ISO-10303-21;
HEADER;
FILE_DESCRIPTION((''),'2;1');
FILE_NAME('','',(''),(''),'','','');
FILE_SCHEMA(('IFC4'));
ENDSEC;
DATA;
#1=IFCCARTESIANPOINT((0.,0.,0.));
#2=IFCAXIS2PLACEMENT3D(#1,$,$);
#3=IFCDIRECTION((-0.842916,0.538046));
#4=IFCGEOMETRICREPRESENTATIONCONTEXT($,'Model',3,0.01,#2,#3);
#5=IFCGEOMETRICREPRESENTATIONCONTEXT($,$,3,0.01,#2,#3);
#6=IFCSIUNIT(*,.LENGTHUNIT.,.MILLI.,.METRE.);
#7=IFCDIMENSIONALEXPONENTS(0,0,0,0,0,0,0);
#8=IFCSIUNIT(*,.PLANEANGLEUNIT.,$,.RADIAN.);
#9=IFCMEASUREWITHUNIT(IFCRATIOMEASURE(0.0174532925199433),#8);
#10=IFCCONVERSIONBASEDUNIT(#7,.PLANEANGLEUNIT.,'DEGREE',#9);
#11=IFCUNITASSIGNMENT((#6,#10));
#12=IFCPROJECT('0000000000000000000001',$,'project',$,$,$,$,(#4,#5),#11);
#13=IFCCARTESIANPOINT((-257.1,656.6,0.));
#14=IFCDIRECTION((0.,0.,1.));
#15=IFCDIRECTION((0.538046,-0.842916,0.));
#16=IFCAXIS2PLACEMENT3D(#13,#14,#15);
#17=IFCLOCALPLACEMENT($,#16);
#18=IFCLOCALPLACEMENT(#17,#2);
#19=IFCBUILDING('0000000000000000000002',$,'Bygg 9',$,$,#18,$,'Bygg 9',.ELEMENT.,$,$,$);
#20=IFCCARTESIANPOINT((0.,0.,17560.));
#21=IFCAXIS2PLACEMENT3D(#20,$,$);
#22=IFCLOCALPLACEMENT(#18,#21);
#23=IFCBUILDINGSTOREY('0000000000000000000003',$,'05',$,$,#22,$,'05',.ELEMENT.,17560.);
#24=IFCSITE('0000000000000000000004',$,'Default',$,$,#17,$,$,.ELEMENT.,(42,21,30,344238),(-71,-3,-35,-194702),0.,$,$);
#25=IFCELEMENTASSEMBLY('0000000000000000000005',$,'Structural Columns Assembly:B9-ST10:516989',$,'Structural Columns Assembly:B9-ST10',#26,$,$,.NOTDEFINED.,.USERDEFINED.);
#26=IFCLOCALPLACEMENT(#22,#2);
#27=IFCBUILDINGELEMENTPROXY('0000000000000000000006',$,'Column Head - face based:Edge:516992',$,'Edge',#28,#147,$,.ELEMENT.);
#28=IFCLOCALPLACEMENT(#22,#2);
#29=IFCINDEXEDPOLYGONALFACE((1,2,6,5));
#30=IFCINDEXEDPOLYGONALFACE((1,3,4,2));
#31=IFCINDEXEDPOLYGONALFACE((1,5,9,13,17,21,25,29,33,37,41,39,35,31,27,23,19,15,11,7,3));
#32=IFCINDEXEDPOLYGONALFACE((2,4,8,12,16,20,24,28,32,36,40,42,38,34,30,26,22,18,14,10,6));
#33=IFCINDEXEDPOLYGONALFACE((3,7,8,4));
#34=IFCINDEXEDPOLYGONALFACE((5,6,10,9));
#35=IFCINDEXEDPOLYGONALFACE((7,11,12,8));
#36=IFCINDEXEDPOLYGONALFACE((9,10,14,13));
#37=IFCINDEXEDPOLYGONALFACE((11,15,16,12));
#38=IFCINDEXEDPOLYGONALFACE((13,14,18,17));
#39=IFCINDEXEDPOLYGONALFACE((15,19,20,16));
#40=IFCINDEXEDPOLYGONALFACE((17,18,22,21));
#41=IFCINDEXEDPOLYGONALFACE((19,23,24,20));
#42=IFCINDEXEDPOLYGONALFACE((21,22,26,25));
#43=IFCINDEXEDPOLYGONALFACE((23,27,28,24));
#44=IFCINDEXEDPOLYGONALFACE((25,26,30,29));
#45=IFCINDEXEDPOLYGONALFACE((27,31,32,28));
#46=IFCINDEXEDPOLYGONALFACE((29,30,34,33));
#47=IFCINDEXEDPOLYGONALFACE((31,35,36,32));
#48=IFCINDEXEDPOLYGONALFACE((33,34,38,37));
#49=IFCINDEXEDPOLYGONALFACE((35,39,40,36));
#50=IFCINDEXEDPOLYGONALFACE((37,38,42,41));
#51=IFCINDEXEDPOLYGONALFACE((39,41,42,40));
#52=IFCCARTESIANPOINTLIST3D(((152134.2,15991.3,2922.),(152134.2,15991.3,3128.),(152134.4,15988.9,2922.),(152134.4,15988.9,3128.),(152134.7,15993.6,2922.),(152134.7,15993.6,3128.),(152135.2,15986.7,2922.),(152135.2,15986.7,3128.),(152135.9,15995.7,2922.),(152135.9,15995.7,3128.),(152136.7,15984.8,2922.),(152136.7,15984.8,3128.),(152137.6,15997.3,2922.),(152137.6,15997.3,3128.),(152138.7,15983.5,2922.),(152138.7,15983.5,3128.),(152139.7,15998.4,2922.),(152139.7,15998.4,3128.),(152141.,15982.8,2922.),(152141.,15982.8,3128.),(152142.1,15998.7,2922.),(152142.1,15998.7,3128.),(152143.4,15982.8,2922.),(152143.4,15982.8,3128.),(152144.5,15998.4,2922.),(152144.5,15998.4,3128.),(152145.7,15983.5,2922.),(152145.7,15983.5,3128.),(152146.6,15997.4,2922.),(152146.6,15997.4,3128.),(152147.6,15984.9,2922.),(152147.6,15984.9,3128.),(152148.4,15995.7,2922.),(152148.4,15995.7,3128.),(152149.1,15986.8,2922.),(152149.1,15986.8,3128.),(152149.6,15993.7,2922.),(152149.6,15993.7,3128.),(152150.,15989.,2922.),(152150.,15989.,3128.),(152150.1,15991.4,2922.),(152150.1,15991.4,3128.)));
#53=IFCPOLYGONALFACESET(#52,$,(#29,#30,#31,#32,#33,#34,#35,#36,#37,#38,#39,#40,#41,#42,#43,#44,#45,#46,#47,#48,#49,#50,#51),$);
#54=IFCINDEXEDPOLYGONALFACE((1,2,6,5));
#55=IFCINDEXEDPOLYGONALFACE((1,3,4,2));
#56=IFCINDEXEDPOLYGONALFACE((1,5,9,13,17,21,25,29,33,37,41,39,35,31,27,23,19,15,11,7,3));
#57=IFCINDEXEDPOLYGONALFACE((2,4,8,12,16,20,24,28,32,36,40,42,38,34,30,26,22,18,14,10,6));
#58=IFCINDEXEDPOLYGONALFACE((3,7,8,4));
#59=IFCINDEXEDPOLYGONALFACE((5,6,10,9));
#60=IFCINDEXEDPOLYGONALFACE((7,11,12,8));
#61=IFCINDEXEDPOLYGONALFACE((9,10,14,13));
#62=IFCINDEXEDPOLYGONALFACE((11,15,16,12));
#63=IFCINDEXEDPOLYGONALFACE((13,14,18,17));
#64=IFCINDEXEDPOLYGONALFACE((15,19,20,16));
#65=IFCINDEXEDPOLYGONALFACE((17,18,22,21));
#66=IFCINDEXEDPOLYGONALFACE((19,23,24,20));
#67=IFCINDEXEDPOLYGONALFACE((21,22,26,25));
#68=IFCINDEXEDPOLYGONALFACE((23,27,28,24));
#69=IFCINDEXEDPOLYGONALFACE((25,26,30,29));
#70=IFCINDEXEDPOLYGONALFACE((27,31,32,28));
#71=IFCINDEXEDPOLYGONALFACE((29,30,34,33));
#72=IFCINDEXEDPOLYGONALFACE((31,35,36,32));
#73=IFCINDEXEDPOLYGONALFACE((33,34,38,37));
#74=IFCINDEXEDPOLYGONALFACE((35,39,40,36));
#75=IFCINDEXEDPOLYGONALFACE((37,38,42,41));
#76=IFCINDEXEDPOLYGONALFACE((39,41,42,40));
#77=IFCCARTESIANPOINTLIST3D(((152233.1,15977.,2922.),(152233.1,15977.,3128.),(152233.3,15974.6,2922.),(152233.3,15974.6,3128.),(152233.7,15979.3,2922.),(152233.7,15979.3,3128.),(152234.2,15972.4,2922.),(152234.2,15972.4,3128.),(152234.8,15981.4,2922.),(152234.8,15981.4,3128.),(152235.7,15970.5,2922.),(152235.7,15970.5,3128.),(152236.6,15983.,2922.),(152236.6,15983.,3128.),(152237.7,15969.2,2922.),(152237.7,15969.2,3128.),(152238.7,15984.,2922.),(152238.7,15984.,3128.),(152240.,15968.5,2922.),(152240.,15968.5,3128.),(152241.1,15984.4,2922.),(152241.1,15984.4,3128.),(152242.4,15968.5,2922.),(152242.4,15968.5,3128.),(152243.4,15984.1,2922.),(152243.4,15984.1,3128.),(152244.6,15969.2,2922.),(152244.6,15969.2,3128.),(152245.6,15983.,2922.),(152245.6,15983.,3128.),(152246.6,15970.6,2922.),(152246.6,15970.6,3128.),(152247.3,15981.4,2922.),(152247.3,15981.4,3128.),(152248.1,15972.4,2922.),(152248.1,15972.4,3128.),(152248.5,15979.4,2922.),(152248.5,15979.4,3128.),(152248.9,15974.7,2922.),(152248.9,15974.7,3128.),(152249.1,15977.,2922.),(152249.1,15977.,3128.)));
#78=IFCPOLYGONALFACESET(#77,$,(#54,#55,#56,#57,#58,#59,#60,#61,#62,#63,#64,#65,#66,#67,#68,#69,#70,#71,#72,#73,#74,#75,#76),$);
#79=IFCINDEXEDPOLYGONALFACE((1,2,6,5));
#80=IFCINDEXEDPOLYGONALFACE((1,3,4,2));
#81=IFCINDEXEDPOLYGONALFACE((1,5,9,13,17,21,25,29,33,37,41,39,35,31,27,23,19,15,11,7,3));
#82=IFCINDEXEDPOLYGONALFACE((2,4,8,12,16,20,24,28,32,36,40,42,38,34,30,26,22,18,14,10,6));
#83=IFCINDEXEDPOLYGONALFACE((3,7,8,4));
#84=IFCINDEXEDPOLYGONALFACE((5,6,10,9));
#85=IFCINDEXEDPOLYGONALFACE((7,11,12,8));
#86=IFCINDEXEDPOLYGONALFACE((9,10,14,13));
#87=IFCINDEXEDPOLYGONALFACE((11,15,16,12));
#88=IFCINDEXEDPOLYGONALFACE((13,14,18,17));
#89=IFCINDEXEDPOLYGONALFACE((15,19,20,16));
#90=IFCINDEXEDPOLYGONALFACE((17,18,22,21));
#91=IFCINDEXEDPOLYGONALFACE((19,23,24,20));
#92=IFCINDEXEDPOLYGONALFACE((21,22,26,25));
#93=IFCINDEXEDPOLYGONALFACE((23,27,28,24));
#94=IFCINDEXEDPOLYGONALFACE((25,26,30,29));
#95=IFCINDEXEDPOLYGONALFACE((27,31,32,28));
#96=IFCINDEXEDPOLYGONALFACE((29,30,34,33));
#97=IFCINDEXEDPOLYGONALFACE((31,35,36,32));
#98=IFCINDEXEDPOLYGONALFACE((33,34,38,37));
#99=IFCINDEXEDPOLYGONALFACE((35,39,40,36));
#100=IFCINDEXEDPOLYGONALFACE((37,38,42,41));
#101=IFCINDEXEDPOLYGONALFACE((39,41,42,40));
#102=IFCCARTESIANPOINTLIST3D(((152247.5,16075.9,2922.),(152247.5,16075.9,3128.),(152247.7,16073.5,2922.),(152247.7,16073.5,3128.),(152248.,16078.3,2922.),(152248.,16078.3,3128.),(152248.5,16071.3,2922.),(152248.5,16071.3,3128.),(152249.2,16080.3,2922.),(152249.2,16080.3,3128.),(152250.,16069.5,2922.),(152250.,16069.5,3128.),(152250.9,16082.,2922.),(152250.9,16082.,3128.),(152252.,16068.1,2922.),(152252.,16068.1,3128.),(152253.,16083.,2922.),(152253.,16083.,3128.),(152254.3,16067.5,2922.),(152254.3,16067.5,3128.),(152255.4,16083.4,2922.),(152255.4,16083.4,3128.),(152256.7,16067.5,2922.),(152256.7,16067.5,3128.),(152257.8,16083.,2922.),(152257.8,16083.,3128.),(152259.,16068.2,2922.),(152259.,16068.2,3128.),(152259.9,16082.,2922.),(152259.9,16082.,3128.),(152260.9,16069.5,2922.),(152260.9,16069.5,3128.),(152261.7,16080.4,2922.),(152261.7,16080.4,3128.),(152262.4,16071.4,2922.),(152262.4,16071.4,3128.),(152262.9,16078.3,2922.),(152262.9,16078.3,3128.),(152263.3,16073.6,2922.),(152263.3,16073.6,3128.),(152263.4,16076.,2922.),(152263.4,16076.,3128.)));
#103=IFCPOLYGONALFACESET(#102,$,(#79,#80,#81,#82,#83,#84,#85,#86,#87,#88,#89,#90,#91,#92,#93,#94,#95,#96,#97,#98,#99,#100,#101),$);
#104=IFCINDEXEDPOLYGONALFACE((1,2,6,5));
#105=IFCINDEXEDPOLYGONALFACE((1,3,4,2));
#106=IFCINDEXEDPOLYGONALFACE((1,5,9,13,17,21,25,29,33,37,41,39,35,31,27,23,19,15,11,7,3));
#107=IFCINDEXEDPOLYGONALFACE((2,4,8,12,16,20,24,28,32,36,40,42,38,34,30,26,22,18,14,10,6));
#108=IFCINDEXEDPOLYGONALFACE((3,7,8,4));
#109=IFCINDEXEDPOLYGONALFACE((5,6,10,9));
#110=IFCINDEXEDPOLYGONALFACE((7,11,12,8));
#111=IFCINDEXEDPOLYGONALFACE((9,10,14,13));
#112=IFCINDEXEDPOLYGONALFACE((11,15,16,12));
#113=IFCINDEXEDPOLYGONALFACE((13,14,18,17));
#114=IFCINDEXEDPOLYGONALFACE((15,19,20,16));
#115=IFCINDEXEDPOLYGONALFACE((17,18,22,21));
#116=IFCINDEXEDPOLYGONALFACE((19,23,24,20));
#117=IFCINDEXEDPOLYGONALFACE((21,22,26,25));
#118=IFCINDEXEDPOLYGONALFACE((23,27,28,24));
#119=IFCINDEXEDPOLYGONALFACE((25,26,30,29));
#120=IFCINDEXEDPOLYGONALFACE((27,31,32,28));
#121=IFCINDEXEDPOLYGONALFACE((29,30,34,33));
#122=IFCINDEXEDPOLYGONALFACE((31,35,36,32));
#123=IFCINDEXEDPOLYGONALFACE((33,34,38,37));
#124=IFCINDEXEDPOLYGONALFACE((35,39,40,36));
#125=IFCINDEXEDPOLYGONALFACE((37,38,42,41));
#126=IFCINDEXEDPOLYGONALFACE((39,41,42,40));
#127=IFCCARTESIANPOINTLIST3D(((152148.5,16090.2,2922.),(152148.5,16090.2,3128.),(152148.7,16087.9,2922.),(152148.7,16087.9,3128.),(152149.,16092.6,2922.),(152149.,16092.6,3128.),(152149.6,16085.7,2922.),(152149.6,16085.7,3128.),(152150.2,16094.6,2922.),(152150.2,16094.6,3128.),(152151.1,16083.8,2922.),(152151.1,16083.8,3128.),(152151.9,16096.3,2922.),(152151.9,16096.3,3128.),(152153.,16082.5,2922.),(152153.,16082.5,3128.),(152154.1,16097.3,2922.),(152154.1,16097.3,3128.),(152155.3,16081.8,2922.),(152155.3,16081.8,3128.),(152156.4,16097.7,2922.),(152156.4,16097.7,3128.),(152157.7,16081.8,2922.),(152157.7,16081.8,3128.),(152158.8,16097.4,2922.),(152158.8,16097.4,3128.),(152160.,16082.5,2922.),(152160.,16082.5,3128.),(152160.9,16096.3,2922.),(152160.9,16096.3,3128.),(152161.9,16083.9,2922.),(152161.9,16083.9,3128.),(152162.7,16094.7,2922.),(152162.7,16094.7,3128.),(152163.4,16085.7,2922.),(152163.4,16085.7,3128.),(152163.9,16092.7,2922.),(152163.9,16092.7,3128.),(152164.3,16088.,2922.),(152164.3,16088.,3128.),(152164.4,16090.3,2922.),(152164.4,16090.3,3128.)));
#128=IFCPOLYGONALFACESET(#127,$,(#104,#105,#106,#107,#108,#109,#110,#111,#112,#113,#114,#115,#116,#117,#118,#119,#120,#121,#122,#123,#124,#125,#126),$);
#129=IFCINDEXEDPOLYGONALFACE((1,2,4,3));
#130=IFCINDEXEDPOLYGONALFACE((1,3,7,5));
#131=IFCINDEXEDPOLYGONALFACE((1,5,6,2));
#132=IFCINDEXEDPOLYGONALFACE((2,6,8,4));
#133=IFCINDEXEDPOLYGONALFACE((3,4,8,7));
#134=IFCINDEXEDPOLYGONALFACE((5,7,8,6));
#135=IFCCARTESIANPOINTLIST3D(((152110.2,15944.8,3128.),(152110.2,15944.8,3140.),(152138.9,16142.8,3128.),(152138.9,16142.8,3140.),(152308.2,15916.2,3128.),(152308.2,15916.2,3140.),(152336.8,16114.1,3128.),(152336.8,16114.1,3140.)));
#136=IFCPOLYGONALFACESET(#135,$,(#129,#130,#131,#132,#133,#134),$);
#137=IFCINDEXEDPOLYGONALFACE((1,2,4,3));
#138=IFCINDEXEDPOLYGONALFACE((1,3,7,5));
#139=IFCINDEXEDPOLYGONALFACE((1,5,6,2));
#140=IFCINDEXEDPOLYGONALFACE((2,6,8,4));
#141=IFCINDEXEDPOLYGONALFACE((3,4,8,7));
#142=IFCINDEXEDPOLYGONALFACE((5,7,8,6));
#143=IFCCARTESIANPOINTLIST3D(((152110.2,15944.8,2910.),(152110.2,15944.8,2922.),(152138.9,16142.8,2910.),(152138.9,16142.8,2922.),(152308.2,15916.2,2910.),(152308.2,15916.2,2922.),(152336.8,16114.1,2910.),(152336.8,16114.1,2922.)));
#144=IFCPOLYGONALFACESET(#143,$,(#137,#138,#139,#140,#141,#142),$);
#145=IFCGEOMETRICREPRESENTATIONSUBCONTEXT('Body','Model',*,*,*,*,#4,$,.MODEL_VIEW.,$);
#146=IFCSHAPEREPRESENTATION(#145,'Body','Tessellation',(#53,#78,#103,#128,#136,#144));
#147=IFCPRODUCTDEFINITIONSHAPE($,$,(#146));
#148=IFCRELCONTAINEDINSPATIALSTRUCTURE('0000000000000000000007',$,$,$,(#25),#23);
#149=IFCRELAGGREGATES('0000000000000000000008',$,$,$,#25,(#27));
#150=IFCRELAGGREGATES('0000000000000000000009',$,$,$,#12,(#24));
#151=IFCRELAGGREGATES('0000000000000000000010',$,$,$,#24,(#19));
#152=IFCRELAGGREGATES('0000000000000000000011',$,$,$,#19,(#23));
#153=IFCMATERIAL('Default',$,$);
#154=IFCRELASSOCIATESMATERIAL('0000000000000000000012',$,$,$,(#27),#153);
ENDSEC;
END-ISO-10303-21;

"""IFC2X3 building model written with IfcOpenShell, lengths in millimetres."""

from ifc_helpers import new_model, entity, si_unit, converted_unit, direction, frame, frame_2d, origin, origin_2d_with_axis, place, context, subcontext, project, spatial, rectangle, circle, extrude, source, transform, mapped, material, element, aggregate, save


model = new_model("IFC2X3")

# Units and contexts
model_context = context("Model", 3, precision=0.01, world=origin(), true_north=direction((-0.842916, 0.538046)))
context_of_model = context(None, 3, precision=0.01, world=origin(), true_north=direction((-0.842916, 0.538046)))
body_context = subcontext(model_context, "Body", "Model", "MODEL_VIEW")
ifc_project = project(units=[si_unit("LENGTHUNIT", "METRE", prefix="MILLI"), converted_unit("PLANEANGLEUNIT", "DEGREE", entity("IfcRatioMeasure", 0.0174532925199433), si_unit("PLANEANGLEUNIT", "RADIAN"), dimensions=[0, 0, 0, 0, 0, 0, 0])], contexts=[model_context, context_of_model])

# Site, building, storey
site_placement = place(None, frame((-257.1, 656.6, 0.0), z_axis=(0.0, 0.0, 1.0), x_axis=(0.538046, -0.842916, 0.0)))
site = spatial("IfcSite", under=ifc_project, at=site_placement, Name="Default", CompositionType="ELEMENT", RefLatitude=(42, 21, 30, 344238), RefLongitude=(-71, -3, -35, -194702), RefElevation=0.0)
building_placement = place(site_placement, origin())
building = spatial("IfcBuilding", under=site, at=building_placement, Name="Bygg 9", LongName="Bygg 9", CompositionType="ELEMENT")
storey_placement = place(building_placement, frame((0.0, 0.0, 17560.0)))
storey = spatial("IfcBuildingStorey", under=building, at=storey_placement, Name="05", LongName="05", CompositionType="ELEMENT", Elevation=17560.0)

# Element assembly
assembly_1_placement = place(storey_placement, origin())
assembly_1 = element("IfcElementAssembly", 1, at=assembly_1_placement, inside=storey, Name="Structural Columns Assembly:B9-ST10:516989", ObjectType="Structural Columns Assembly:B9-ST10", AssemblyPlace="NOTDEFINED", PredefinedType="USERDEFINED")

# Building element proxy
ifc_material_1 = material(Name="Default")
shared_shape_1 = source(origin(), body_context, "Body", "SweptSolid", [
    extrude(circle(Radius=8.0, at=frame_2d((0.0, 0.0), x_axis=(1.0, 0.0))), frame((50.0, -75.0, 12.0)), (0.0, 0.0, 1.0), 206.0),
    extrude(circle(Radius=8.0, at=frame_2d((0.0, 0.0), x_axis=(1.0, 0.0))), frame((50.0, 25.0, 12.0)), (0.0, 0.0, 1.0), 206.0),
    extrude(circle(Radius=8.0, at=frame_2d((0.0, 0.0), x_axis=(1.0, 0.0))), frame((-50.0, 25.0, 12.0)), (0.0, 0.0, 1.0), 206.0),
    extrude(circle(Radius=8.0, at=frame_2d((0.0, 0.0), x_axis=(1.0, 0.0))), frame((-50.0, -75.0, 12.0)), (0.0, 0.0, 1.0), 206.0),
    extrude(rectangle(XDim=200.0, YDim=200.0, at=origin_2d_with_axis()), frame((0.0, 0.0, 218.0), z_axis=(0.0, 0.0, 1.0), x_axis=(-1.0, 0.0, 0.0)), (0.0, 0.0, 1.0), 12.0),
    extrude(rectangle(XDim=200.0, YDim=200.0, at=origin_2d_with_axis()), frame((0.0, 0.0, 0.0), z_axis=(0.0, 0.0, 1.0), x_axis=(0.0, 1.0, 0.0)), (0.0, 0.0, 1.0), 12.0),
])
proxy_1_placement = place(assembly_1_placement, frame((152223.5, 16029.5, 2910.0), z_axis=(0.0, 0.0, 1.0), x_axis=(-0.143216, -0.989691, 0.0)))
proxy_1 = element("IfcBuildingElementProxy", 2, at=proxy_1_placement, material=ifc_material_1, Name="Column Head - face based:Edge:516992", ObjectType="Edge", CompositionType="ELEMENT", context=body_context, shape_type="MappedRepresentation", body=[
    mapped(shared_shape_1, transform((0.0, 0.0, 0.0), scale=1.0)),
])
aggregate(assembly_1, [proxy_1])

save(model, "model.ifc")
